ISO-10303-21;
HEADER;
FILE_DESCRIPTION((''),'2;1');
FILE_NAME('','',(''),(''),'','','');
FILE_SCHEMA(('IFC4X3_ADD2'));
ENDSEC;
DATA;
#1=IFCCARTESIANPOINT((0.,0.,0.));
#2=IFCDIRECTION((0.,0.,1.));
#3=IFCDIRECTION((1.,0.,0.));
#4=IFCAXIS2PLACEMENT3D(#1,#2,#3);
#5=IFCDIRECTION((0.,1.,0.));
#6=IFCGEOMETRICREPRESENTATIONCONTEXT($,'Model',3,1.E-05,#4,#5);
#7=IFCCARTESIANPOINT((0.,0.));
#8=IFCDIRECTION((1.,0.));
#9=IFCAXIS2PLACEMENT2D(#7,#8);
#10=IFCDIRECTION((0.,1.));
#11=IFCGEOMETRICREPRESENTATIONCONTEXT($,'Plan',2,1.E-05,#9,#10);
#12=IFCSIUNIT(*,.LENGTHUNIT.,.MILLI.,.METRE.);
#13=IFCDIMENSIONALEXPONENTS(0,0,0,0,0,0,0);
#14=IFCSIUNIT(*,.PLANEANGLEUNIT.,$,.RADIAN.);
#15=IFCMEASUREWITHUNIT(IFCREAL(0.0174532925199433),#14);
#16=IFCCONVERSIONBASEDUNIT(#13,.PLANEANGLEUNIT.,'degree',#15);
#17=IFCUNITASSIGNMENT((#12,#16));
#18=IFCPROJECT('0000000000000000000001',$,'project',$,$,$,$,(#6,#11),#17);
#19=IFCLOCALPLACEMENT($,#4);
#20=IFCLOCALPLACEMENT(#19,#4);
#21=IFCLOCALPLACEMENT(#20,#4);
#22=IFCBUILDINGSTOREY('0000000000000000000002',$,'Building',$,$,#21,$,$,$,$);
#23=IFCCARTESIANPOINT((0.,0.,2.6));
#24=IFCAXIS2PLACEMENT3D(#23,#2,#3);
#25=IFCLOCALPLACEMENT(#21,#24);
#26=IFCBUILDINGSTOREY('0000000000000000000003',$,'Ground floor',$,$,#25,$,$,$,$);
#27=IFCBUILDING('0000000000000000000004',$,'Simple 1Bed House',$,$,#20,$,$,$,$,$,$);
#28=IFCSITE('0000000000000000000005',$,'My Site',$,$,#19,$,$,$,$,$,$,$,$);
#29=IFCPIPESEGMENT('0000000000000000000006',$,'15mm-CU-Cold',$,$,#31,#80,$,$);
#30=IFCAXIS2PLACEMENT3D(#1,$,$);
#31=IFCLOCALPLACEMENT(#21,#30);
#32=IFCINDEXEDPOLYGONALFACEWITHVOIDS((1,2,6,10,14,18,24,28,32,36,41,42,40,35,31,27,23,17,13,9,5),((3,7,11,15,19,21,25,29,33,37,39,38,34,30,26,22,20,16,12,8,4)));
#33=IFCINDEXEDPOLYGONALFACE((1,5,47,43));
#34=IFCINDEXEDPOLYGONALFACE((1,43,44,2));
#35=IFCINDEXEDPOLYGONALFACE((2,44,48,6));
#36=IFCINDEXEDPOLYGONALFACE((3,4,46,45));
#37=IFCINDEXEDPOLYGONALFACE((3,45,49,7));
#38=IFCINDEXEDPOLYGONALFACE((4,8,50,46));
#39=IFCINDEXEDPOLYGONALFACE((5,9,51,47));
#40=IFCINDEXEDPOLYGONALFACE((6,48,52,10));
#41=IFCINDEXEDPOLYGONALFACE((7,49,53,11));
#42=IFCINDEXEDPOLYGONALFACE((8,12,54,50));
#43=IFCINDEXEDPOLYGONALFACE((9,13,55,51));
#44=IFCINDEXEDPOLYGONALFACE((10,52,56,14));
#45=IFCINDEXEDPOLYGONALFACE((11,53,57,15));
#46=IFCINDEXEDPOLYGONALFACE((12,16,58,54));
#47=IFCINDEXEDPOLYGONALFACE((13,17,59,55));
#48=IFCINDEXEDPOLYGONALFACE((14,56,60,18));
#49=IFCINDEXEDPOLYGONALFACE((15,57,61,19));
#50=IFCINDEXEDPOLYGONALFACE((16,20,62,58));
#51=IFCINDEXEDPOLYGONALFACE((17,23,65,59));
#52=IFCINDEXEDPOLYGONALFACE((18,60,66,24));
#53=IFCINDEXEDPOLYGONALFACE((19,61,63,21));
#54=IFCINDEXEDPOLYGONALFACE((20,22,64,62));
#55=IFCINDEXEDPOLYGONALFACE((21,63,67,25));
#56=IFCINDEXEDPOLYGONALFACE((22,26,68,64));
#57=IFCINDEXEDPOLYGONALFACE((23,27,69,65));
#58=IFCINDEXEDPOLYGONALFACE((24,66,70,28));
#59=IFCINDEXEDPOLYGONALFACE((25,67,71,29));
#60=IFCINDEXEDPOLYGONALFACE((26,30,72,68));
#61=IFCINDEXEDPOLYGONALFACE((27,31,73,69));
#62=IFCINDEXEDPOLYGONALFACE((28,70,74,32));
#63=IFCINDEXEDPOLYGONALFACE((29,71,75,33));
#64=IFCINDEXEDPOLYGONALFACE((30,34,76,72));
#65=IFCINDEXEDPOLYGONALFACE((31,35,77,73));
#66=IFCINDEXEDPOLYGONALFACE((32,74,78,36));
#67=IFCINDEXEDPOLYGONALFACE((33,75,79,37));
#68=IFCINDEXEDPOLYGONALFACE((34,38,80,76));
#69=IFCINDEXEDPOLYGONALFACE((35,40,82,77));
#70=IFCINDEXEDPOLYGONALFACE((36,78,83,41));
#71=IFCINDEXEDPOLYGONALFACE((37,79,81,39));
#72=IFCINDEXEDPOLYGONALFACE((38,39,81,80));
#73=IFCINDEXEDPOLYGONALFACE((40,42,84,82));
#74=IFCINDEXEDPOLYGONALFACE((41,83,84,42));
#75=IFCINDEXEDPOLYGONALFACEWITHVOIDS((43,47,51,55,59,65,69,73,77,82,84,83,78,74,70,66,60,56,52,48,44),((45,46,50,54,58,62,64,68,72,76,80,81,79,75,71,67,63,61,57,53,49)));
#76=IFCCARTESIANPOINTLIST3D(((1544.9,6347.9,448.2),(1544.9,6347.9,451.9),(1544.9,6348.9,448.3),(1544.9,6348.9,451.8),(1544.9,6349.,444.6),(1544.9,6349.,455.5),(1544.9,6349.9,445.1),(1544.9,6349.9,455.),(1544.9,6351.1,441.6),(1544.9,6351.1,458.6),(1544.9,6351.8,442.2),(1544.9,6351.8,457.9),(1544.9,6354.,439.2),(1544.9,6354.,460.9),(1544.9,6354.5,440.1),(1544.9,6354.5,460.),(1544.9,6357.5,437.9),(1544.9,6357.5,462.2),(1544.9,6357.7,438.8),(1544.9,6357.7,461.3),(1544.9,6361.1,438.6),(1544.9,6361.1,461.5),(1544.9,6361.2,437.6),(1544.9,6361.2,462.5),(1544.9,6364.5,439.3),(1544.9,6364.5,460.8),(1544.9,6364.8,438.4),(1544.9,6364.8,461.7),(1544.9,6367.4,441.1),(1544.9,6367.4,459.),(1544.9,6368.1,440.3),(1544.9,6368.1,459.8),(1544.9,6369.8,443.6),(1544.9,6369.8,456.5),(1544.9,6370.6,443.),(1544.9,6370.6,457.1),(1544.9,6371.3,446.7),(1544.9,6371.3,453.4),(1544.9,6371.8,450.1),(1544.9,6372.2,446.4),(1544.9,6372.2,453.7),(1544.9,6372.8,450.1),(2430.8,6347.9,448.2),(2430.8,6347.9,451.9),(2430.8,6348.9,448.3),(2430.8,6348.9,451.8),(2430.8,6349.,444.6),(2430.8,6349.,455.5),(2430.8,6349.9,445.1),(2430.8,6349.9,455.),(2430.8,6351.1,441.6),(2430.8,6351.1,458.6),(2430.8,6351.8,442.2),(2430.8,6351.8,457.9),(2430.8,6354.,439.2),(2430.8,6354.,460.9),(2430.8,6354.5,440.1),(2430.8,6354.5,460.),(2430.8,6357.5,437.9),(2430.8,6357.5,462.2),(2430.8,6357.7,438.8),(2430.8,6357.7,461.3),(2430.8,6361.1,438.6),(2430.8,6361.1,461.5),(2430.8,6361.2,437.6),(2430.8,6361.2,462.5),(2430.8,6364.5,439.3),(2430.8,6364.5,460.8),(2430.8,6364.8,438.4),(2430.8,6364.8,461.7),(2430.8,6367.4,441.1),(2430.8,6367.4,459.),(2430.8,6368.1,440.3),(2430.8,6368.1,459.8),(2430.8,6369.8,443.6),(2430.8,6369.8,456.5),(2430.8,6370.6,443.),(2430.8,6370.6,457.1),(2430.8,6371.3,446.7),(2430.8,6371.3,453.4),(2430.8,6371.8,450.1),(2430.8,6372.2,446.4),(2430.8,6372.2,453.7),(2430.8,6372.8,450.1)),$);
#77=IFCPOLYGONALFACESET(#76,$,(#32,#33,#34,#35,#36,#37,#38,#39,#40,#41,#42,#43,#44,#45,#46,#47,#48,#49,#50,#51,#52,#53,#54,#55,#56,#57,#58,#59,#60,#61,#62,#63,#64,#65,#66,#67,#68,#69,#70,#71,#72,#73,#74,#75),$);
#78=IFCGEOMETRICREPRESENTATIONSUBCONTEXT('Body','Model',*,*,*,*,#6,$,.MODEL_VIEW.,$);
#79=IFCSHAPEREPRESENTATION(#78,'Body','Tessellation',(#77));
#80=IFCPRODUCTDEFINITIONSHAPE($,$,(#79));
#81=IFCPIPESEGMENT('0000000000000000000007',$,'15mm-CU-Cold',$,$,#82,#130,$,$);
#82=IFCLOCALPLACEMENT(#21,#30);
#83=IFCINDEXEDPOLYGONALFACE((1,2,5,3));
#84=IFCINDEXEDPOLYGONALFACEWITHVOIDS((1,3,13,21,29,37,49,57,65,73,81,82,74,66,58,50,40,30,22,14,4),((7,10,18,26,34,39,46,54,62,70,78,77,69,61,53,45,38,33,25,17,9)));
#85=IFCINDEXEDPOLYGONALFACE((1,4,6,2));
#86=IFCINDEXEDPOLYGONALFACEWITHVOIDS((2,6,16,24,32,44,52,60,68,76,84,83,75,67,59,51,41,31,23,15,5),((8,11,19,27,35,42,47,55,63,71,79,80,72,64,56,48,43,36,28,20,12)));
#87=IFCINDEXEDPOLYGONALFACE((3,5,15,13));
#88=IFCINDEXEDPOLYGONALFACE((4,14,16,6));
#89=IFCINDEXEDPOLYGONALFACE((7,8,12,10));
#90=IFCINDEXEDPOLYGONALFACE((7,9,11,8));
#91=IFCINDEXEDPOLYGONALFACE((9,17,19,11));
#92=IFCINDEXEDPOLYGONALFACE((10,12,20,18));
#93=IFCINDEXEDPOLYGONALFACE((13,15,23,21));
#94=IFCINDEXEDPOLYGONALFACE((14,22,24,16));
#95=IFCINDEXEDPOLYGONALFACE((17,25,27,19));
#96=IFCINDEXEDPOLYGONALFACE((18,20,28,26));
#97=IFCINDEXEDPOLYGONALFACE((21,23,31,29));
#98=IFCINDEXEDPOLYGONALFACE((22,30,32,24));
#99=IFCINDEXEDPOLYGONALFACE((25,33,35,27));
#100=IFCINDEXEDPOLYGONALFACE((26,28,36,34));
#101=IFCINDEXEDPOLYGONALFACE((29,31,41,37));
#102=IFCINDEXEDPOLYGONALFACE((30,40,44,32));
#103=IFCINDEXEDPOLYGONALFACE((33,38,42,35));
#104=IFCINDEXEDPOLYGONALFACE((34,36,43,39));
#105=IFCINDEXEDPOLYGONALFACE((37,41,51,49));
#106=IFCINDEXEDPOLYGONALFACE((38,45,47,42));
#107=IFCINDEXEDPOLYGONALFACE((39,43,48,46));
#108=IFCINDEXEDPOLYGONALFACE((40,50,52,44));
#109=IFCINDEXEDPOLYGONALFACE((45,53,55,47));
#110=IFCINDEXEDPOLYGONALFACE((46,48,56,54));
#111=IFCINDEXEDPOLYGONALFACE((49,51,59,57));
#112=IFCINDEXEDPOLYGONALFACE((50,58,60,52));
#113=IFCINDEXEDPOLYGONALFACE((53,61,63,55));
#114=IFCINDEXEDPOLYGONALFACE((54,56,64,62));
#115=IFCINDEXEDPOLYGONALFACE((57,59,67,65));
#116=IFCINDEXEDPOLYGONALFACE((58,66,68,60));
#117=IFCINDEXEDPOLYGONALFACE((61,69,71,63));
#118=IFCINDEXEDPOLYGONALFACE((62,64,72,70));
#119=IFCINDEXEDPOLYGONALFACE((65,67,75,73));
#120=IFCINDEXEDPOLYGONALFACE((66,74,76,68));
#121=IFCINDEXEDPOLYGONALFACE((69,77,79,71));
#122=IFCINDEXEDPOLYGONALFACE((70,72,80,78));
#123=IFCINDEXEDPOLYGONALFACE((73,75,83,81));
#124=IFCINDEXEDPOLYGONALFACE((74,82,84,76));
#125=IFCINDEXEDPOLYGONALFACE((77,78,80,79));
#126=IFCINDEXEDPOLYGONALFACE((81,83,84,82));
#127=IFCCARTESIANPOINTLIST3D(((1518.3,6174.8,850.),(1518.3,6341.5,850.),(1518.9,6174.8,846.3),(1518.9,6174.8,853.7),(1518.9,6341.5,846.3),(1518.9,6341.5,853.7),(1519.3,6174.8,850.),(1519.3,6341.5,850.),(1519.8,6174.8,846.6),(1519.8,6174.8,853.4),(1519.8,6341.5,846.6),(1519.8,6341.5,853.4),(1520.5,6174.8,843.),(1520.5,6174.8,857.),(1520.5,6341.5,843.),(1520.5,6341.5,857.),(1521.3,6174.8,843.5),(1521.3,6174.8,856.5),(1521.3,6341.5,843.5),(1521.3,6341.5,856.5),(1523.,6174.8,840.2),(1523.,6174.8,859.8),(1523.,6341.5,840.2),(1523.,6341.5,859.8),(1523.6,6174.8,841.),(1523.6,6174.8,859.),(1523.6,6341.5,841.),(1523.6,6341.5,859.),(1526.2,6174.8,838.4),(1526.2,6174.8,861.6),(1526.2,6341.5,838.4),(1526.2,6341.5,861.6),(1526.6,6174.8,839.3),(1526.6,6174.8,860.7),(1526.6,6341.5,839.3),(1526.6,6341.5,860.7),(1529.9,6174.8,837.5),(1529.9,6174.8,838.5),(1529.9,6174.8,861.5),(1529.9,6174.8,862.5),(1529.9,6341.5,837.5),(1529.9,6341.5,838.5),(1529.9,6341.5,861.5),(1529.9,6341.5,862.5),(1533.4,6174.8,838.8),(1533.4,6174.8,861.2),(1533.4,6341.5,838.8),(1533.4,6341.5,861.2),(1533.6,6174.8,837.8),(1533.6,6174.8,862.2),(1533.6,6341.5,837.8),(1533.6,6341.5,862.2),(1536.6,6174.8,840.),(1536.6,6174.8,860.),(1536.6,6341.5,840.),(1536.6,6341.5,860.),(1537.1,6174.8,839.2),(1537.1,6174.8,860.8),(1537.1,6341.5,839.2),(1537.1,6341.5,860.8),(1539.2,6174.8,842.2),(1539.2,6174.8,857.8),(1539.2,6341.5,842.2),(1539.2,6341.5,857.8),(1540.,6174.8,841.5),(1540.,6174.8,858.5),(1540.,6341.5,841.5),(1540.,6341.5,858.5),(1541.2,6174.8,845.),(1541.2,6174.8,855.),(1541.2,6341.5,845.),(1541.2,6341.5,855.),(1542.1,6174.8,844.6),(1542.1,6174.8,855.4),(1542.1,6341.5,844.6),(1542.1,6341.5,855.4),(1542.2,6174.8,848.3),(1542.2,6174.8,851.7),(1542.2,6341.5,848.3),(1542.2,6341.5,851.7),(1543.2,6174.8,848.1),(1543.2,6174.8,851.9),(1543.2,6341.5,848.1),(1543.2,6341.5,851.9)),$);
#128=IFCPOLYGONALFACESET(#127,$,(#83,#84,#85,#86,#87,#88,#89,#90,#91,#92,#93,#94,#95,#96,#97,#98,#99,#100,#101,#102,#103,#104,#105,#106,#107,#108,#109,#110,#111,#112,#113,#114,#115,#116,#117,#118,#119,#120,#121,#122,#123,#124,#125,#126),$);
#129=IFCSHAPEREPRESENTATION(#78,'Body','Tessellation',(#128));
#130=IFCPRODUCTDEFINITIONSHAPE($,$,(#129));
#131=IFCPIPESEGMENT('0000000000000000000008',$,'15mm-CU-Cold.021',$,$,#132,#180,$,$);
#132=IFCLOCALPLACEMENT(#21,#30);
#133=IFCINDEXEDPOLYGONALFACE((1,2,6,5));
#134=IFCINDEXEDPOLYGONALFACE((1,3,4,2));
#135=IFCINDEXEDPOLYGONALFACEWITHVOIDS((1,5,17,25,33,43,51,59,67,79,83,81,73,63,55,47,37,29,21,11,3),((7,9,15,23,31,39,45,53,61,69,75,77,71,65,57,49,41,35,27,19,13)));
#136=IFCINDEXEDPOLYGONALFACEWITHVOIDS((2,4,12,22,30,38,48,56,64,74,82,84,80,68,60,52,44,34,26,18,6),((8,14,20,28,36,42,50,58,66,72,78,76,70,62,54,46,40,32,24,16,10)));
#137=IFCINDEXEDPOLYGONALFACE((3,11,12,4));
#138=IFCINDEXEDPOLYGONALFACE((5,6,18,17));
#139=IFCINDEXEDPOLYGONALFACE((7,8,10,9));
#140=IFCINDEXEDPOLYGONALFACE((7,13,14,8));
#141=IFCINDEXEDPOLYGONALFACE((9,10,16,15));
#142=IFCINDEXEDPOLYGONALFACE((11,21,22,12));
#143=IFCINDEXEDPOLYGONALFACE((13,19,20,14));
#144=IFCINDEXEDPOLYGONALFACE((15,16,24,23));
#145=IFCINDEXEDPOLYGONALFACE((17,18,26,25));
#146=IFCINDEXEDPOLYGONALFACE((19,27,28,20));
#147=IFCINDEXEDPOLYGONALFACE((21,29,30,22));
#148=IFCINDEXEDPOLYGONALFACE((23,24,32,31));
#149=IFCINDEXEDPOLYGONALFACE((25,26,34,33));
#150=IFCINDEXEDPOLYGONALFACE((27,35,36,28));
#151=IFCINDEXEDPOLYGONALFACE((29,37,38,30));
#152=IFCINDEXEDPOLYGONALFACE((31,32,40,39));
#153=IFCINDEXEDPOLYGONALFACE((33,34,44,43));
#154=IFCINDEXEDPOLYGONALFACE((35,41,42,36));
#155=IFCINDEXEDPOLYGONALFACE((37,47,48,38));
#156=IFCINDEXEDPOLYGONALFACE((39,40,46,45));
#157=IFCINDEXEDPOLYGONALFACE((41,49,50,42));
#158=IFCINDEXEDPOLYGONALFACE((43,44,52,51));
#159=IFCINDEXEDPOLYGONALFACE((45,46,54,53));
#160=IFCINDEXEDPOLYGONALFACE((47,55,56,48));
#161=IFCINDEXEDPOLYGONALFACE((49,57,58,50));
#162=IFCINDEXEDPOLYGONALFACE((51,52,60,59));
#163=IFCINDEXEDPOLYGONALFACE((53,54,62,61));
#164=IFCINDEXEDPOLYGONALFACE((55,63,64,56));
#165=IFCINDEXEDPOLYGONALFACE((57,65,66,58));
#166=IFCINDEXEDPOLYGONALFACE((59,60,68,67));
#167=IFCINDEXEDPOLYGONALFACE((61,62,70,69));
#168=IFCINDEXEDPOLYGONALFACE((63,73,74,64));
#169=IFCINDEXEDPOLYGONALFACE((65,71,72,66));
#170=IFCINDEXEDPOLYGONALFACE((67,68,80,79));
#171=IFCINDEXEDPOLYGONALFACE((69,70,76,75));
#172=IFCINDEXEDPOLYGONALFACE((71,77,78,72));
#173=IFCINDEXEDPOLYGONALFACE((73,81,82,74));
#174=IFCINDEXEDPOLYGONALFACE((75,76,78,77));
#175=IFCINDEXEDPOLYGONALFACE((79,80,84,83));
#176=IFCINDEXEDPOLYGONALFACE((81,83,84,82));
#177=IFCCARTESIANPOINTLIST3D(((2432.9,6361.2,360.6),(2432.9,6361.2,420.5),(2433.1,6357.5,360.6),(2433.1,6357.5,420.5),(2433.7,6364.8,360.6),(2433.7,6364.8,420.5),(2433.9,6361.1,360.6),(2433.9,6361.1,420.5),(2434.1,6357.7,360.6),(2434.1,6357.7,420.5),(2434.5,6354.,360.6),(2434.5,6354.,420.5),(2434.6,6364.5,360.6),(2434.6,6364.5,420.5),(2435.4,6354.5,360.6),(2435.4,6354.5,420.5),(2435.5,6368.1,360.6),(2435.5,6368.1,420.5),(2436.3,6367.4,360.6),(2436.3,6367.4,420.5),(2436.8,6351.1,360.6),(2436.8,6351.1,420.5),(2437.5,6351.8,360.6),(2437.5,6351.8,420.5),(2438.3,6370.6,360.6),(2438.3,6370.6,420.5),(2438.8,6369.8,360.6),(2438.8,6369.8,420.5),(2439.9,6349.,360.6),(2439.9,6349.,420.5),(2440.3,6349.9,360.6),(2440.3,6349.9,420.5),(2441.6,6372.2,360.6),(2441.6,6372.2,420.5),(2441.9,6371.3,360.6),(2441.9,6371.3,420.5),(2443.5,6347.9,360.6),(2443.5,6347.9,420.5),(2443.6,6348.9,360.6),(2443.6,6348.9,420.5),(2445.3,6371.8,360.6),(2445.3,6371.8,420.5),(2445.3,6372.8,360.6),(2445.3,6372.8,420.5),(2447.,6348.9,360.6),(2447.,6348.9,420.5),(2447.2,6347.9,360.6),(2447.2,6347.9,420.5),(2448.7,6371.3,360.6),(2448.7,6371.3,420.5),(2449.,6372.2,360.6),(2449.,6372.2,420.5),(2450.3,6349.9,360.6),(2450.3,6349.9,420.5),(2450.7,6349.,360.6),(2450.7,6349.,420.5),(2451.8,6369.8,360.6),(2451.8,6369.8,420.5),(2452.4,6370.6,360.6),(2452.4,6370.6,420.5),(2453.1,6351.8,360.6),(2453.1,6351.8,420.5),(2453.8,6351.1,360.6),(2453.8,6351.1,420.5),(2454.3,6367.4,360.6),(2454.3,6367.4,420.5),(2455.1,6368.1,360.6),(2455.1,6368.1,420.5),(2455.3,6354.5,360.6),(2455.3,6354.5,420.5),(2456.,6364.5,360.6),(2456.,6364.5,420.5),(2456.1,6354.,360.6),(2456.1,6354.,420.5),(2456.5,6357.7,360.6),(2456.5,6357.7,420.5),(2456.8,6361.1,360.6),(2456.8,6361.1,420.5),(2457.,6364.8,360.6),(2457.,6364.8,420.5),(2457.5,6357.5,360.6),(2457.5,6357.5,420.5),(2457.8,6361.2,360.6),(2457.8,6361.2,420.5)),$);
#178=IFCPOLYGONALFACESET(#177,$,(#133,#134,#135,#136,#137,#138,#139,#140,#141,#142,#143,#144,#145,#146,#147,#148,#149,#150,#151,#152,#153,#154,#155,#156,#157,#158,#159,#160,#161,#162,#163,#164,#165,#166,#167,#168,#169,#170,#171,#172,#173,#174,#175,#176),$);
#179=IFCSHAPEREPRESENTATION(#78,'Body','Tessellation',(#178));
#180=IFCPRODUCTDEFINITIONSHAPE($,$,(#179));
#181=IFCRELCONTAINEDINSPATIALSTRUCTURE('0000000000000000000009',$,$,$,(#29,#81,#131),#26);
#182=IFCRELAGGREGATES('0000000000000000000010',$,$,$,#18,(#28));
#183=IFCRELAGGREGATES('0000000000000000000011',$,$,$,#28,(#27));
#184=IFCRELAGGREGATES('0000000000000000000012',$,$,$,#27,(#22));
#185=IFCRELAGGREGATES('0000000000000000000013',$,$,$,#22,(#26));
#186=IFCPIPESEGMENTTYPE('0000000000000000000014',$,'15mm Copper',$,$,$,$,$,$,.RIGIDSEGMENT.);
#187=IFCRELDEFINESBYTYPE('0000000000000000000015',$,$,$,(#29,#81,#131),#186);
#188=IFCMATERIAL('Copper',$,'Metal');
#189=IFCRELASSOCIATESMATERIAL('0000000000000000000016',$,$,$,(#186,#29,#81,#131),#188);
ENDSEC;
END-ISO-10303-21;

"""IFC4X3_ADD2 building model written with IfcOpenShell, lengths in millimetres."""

from ifc_helpers import new_model, entity, si_unit, converted_unit, direction, frame, origin_with_axes, origin_2d_with_axis, place, context, subcontext, project, spatial, hollow_circle, extrude, material, material_profile, profile_set, profile_usage, type_object, element, save


model = new_model("IFC4X3_ADD2")

# Units and contexts
model_context = context("Model", 3, precision=1e-05, world=origin_with_axes(), true_north=direction((0.0, 1.0, 0.0)))
plan_context = context("Plan", 2, precision=1e-05, world=origin_2d_with_axis(), true_north=direction((0.0, 1.0)))
body_context_1 = subcontext(model_context, "Body", "Model", "MODEL_VIEW")
ifc_project = project(units=[si_unit("LENGTHUNIT", "METRE", prefix="MILLI"), converted_unit("PLANEANGLEUNIT", "degree", entity("IfcReal", 0.0174532925199433), si_unit("PLANEANGLEUNIT", "RADIAN"), dimensions=[0, 0, 0, 0, 0, 0, 0])], contexts=[model_context, plan_context])

# Site, building, storeys
site_placement = place(None, origin_with_axes())
site = spatial("IfcSite", under=ifc_project, at=site_placement, Name="My Site")
building_placement = place(site_placement, origin_with_axes())
building = spatial("IfcBuilding", under=site, at=building_placement, Name="Simple 1Bed House")
storey_1_placement = place(building_placement, origin_with_axes())
storey_1 = spatial("IfcBuildingStorey", under=building, at=storey_1_placement, Name="Building")
storey_2_placement = place(storey_1_placement, frame((0.0, 0.0, 2.6), z_axis=(0.0, 0.0, 1.0), x_axis=(1.0, 0.0, 0.0)))
storey_2 = spatial("IfcBuildingStorey", under=storey_1, at=storey_2_placement, Name="Ground floor")

# Pipe segments
ifc_material_1 = material(Name="Copper", Category="Metal")
ifc_material_profile_1 = material_profile(ifc_material_1, hollow_circle(Radius=12.5, WallThickness=1.0))
ifc_profile_set_1 = profile_set([ifc_material_profile_1])
ifc_profile_usage_1 = profile_usage(ifc_profile_set_1, cardinal=5)
pipe_segment_type_1 = type_object("IfcPipeSegmentType", Name="15mm Copper", PredefinedType="RIGIDSEGMENT", material=ifc_profile_set_1)
pipe_segment_1_placement = place(storey_2_placement, frame((1544.9, 6360.3, 447.5), z_axis=(1.0, 0.0, 0.0), x_axis=(0.0, 1.0, 0.0)))
element("IfcPipeSegment", 1, at=pipe_segment_1_placement, inside=storey_2, type_object=pipe_segment_type_1, material=ifc_profile_usage_1, Name="15mm-CU-Cold", context=body_context_1, shape_type="SweptSolid", body=[
    extrude(hollow_circle(Radius=12.5, WallThickness=1.0), origin_with_axes(), (0.0, 0.0, 1.0), 885.9),
])
ifc_profile_usage_2 = profile_usage(ifc_profile_set_1, cardinal=5)
pipe_segment_2_placement = place(storey_2_placement, frame((1530.8, 6341.5, 847.4), z_axis=(0.0, -1.0, 0.0), x_axis=(-1.0, 0.0, 0.0)))
element("IfcPipeSegment", 2, at=pipe_segment_2_placement, inside=storey_2, type_object=pipe_segment_type_1, material=ifc_profile_usage_2, Name="15mm-CU-Cold", context=body_context_1, shape_type="SweptSolid", body=[
    extrude(hollow_circle(Radius=12.5, WallThickness=1.0), origin_with_axes(), (0.0, 0.0, 1.0), 166.8),
])
ifc_profile_usage_3 = profile_usage(ifc_profile_set_1, cardinal=5)
pipe_segment_3_placement = place(storey_2_placement, frame((2445.3, 6360.3, 358.0), z_axis=(0.0, 0.0, 1.0), x_axis=(0.0, 1.0, 0.0)))
element("IfcPipeSegment", 3, at=pipe_segment_3_placement, inside=storey_2, type_object=pipe_segment_type_1, material=ifc_profile_usage_3, Name="15mm-CU-Cold.021", context=body_context_1, shape_type="SweptSolid", body=[
    extrude(hollow_circle(Radius=12.5, WallThickness=1.0), origin_with_axes(), (0.0, 0.0, 1.0), 59.9),
])

save(model, "model.ifc")
